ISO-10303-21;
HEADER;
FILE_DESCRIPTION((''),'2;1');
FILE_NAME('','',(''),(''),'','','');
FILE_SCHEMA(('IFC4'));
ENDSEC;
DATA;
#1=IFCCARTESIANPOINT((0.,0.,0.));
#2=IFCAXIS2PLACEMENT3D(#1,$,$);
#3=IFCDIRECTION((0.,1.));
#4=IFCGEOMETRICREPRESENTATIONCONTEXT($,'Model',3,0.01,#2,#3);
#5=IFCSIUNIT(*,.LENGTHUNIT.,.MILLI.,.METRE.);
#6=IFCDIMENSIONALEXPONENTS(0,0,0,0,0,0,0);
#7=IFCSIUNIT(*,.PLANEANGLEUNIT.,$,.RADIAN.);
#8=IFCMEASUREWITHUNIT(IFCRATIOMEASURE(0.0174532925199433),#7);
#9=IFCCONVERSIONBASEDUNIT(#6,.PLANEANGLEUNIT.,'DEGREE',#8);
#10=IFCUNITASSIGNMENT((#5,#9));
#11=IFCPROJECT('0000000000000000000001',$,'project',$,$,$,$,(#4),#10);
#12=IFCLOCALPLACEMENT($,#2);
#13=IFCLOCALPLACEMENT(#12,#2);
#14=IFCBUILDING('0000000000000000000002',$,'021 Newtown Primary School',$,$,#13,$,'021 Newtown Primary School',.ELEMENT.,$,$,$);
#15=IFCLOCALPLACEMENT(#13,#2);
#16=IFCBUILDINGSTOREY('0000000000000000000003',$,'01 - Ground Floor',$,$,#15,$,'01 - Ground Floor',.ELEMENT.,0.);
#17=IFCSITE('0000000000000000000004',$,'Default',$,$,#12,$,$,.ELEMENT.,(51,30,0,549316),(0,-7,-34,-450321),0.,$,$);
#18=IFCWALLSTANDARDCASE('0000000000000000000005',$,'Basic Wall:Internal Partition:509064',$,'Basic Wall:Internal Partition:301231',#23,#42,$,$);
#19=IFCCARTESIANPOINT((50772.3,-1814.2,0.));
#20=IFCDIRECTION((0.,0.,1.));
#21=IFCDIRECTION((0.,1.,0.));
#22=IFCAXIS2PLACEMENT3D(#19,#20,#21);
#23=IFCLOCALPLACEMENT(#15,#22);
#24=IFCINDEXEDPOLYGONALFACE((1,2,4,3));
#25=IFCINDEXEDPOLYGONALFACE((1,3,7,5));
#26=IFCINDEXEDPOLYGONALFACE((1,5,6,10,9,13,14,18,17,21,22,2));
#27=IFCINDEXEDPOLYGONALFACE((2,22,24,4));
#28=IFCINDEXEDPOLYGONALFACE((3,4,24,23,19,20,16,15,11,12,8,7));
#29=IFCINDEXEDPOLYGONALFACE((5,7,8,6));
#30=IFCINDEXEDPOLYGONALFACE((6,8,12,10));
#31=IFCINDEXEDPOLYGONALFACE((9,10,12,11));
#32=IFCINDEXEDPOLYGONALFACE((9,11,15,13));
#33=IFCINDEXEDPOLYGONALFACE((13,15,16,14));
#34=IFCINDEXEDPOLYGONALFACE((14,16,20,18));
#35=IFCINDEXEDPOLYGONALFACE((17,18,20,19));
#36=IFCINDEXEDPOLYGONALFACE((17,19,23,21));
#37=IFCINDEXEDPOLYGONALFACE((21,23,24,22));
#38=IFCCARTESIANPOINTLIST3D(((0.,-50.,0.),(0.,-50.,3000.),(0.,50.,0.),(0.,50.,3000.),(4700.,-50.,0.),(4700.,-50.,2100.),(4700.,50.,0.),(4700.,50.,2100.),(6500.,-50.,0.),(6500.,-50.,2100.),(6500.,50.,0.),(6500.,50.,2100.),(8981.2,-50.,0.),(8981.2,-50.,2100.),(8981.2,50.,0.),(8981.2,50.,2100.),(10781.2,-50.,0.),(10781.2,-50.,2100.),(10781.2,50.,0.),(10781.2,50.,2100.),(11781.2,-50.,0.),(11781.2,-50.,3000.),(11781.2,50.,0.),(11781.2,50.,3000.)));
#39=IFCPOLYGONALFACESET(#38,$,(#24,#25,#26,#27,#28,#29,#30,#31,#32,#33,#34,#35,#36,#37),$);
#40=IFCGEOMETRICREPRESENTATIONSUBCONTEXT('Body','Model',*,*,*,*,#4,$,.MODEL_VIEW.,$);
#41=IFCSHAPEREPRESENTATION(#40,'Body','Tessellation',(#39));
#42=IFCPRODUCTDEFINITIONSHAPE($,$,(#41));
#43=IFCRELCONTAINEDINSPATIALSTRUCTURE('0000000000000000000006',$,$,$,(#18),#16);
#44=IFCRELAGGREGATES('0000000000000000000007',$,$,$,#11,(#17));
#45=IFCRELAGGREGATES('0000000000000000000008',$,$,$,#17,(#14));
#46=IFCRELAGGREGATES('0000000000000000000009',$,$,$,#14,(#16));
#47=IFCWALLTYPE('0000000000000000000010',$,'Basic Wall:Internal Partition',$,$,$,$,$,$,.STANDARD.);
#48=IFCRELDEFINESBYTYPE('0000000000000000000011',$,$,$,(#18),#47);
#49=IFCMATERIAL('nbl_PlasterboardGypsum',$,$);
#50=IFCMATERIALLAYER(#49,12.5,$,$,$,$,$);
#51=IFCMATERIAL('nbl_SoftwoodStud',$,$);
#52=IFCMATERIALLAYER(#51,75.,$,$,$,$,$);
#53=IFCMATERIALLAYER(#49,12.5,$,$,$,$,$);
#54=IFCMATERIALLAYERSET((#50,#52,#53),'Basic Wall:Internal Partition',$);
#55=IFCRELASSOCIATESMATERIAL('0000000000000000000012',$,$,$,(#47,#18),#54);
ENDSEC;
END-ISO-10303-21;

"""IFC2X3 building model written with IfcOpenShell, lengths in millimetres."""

from ifc_helpers import new_model, entity, si_unit, converted_unit, direction, frame, frame_2d, origin, place, context, subcontext, project, spatial, rectangle, extrude, material, layer, layer_set, layer_usage, type_object, element, save


model = new_model("IFC2X3")

# Units and contexts
model_context = context("Model", 3, precision=0.01, world=origin(), true_north=direction((0.0, 1.0)))
body_context = subcontext(model_context, "Body", "Model", "MODEL_VIEW")
ifc_project = project(units=[si_unit("LENGTHUNIT", "METRE", prefix="MILLI"), converted_unit("PLANEANGLEUNIT", "DEGREE", entity("IfcRatioMeasure", 0.0174532925199433), si_unit("PLANEANGLEUNIT", "RADIAN"), dimensions=[0, 0, 0, 0, 0, 0, 0])], contexts=[model_context])

# Site, building, storey
site_placement = place(None, origin())
site = spatial("IfcSite", under=ifc_project, at=site_placement, Name="Default", CompositionType="ELEMENT", RefLatitude=(51, 30, 0, 549316), RefLongitude=(0, -7, -34, -450321), RefElevation=0.0)
building_placement = place(site_placement, origin())
building = spatial("IfcBuilding", under=site, at=building_placement, Name="021 Newtown Primary School", LongName="021 Newtown Primary School", CompositionType="ELEMENT")
storey_placement = place(building_placement, origin())
storey = spatial("IfcBuildingStorey", under=building, at=storey_placement, Name="01 - Ground Floor", LongName="01 - Ground Floor", CompositionType="ELEMENT", Elevation=0.0)

# Shared definitions
ifc_material_1 = material(Name="nbl_PlasterboardGypsum")
ifc_layer_1 = layer(ifc_material_1, 12.5)
ifc_material_2 = material(Name="nbl_SoftwoodStud")
ifc_layer_2 = layer(ifc_material_2, 75.0)
ifc_layer_3 = layer(ifc_material_1, 12.5)
ifc_layer_set_1 = layer_set([ifc_layer_1, ifc_layer_2, ifc_layer_3], Name="Basic Wall:Internal Partition")
wall_type_1 = type_object("IfcWallType", Name="Basic Wall:Internal Partition", PredefinedType="STANDARD", material=ifc_layer_set_1)

# Wall, openings
ifc_layer_usage_1 = layer_usage(ifc_layer_set_1, "AXIS2", "NEGATIVE", 50.0)
wall_1_placement = place(storey_placement, frame((50772.3, -1814.2, 0.0), z_axis=(0.0, 0.0, 1.0), x_axis=(0.0, 1.0, 0.0)))
wall_1 = element("IfcWallStandardCase", 1, at=wall_1_placement, inside=storey, type_object=wall_type_1, material=ifc_layer_usage_1, Name="Basic Wall:Internal Partition:509064", ObjectType="Basic Wall:Internal Partition:301231", context=body_context, shape_type="SweptSolid", body=[
    extrude(rectangle(XDim=11781.2, YDim=100.0, at=frame_2d((5890.6, 0.0), x_axis=(-1.0, 0.0))), origin(), (0.0, 0.0, 1.0), 3000.0),
])
opening_1_placement = place(wall_1_placement, origin())
element("IfcOpeningElement", 2, at=opening_1_placement, cuts=wall_1, ObjectType="Opening", context=body_context, shape_type="SweptSolid", body=[
    extrude(rectangle(XDim=2100.0, YDim=1800.0, at=frame_2d((0.0, 0.0), x_axis=(1.0, 0.0))), frame((5600.0, -1474.0, 1050.0), z_axis=(0.0, 1.0, 0.0), x_axis=(0.0, 0.0, 1.0)), (0.0, 0.0, 1.0), 3048.0),
])
opening_2_placement = place(wall_1_placement, origin())
element("IfcOpeningElement", 3, at=opening_2_placement, cuts=wall_1, ObjectType="Opening", context=body_context, shape_type="SweptSolid", body=[
    extrude(rectangle(XDim=2100.0, YDim=1800.0, at=frame_2d((0.0, 0.0), x_axis=(1.0, 0.0))), frame((9881.2, -1474.0, 1050.0), z_axis=(0.0, 1.0, 0.0), x_axis=(0.0, 0.0, 1.0)), (0.0, 0.0, 1.0), 3048.0),
])

save(model, "model.ifc")
